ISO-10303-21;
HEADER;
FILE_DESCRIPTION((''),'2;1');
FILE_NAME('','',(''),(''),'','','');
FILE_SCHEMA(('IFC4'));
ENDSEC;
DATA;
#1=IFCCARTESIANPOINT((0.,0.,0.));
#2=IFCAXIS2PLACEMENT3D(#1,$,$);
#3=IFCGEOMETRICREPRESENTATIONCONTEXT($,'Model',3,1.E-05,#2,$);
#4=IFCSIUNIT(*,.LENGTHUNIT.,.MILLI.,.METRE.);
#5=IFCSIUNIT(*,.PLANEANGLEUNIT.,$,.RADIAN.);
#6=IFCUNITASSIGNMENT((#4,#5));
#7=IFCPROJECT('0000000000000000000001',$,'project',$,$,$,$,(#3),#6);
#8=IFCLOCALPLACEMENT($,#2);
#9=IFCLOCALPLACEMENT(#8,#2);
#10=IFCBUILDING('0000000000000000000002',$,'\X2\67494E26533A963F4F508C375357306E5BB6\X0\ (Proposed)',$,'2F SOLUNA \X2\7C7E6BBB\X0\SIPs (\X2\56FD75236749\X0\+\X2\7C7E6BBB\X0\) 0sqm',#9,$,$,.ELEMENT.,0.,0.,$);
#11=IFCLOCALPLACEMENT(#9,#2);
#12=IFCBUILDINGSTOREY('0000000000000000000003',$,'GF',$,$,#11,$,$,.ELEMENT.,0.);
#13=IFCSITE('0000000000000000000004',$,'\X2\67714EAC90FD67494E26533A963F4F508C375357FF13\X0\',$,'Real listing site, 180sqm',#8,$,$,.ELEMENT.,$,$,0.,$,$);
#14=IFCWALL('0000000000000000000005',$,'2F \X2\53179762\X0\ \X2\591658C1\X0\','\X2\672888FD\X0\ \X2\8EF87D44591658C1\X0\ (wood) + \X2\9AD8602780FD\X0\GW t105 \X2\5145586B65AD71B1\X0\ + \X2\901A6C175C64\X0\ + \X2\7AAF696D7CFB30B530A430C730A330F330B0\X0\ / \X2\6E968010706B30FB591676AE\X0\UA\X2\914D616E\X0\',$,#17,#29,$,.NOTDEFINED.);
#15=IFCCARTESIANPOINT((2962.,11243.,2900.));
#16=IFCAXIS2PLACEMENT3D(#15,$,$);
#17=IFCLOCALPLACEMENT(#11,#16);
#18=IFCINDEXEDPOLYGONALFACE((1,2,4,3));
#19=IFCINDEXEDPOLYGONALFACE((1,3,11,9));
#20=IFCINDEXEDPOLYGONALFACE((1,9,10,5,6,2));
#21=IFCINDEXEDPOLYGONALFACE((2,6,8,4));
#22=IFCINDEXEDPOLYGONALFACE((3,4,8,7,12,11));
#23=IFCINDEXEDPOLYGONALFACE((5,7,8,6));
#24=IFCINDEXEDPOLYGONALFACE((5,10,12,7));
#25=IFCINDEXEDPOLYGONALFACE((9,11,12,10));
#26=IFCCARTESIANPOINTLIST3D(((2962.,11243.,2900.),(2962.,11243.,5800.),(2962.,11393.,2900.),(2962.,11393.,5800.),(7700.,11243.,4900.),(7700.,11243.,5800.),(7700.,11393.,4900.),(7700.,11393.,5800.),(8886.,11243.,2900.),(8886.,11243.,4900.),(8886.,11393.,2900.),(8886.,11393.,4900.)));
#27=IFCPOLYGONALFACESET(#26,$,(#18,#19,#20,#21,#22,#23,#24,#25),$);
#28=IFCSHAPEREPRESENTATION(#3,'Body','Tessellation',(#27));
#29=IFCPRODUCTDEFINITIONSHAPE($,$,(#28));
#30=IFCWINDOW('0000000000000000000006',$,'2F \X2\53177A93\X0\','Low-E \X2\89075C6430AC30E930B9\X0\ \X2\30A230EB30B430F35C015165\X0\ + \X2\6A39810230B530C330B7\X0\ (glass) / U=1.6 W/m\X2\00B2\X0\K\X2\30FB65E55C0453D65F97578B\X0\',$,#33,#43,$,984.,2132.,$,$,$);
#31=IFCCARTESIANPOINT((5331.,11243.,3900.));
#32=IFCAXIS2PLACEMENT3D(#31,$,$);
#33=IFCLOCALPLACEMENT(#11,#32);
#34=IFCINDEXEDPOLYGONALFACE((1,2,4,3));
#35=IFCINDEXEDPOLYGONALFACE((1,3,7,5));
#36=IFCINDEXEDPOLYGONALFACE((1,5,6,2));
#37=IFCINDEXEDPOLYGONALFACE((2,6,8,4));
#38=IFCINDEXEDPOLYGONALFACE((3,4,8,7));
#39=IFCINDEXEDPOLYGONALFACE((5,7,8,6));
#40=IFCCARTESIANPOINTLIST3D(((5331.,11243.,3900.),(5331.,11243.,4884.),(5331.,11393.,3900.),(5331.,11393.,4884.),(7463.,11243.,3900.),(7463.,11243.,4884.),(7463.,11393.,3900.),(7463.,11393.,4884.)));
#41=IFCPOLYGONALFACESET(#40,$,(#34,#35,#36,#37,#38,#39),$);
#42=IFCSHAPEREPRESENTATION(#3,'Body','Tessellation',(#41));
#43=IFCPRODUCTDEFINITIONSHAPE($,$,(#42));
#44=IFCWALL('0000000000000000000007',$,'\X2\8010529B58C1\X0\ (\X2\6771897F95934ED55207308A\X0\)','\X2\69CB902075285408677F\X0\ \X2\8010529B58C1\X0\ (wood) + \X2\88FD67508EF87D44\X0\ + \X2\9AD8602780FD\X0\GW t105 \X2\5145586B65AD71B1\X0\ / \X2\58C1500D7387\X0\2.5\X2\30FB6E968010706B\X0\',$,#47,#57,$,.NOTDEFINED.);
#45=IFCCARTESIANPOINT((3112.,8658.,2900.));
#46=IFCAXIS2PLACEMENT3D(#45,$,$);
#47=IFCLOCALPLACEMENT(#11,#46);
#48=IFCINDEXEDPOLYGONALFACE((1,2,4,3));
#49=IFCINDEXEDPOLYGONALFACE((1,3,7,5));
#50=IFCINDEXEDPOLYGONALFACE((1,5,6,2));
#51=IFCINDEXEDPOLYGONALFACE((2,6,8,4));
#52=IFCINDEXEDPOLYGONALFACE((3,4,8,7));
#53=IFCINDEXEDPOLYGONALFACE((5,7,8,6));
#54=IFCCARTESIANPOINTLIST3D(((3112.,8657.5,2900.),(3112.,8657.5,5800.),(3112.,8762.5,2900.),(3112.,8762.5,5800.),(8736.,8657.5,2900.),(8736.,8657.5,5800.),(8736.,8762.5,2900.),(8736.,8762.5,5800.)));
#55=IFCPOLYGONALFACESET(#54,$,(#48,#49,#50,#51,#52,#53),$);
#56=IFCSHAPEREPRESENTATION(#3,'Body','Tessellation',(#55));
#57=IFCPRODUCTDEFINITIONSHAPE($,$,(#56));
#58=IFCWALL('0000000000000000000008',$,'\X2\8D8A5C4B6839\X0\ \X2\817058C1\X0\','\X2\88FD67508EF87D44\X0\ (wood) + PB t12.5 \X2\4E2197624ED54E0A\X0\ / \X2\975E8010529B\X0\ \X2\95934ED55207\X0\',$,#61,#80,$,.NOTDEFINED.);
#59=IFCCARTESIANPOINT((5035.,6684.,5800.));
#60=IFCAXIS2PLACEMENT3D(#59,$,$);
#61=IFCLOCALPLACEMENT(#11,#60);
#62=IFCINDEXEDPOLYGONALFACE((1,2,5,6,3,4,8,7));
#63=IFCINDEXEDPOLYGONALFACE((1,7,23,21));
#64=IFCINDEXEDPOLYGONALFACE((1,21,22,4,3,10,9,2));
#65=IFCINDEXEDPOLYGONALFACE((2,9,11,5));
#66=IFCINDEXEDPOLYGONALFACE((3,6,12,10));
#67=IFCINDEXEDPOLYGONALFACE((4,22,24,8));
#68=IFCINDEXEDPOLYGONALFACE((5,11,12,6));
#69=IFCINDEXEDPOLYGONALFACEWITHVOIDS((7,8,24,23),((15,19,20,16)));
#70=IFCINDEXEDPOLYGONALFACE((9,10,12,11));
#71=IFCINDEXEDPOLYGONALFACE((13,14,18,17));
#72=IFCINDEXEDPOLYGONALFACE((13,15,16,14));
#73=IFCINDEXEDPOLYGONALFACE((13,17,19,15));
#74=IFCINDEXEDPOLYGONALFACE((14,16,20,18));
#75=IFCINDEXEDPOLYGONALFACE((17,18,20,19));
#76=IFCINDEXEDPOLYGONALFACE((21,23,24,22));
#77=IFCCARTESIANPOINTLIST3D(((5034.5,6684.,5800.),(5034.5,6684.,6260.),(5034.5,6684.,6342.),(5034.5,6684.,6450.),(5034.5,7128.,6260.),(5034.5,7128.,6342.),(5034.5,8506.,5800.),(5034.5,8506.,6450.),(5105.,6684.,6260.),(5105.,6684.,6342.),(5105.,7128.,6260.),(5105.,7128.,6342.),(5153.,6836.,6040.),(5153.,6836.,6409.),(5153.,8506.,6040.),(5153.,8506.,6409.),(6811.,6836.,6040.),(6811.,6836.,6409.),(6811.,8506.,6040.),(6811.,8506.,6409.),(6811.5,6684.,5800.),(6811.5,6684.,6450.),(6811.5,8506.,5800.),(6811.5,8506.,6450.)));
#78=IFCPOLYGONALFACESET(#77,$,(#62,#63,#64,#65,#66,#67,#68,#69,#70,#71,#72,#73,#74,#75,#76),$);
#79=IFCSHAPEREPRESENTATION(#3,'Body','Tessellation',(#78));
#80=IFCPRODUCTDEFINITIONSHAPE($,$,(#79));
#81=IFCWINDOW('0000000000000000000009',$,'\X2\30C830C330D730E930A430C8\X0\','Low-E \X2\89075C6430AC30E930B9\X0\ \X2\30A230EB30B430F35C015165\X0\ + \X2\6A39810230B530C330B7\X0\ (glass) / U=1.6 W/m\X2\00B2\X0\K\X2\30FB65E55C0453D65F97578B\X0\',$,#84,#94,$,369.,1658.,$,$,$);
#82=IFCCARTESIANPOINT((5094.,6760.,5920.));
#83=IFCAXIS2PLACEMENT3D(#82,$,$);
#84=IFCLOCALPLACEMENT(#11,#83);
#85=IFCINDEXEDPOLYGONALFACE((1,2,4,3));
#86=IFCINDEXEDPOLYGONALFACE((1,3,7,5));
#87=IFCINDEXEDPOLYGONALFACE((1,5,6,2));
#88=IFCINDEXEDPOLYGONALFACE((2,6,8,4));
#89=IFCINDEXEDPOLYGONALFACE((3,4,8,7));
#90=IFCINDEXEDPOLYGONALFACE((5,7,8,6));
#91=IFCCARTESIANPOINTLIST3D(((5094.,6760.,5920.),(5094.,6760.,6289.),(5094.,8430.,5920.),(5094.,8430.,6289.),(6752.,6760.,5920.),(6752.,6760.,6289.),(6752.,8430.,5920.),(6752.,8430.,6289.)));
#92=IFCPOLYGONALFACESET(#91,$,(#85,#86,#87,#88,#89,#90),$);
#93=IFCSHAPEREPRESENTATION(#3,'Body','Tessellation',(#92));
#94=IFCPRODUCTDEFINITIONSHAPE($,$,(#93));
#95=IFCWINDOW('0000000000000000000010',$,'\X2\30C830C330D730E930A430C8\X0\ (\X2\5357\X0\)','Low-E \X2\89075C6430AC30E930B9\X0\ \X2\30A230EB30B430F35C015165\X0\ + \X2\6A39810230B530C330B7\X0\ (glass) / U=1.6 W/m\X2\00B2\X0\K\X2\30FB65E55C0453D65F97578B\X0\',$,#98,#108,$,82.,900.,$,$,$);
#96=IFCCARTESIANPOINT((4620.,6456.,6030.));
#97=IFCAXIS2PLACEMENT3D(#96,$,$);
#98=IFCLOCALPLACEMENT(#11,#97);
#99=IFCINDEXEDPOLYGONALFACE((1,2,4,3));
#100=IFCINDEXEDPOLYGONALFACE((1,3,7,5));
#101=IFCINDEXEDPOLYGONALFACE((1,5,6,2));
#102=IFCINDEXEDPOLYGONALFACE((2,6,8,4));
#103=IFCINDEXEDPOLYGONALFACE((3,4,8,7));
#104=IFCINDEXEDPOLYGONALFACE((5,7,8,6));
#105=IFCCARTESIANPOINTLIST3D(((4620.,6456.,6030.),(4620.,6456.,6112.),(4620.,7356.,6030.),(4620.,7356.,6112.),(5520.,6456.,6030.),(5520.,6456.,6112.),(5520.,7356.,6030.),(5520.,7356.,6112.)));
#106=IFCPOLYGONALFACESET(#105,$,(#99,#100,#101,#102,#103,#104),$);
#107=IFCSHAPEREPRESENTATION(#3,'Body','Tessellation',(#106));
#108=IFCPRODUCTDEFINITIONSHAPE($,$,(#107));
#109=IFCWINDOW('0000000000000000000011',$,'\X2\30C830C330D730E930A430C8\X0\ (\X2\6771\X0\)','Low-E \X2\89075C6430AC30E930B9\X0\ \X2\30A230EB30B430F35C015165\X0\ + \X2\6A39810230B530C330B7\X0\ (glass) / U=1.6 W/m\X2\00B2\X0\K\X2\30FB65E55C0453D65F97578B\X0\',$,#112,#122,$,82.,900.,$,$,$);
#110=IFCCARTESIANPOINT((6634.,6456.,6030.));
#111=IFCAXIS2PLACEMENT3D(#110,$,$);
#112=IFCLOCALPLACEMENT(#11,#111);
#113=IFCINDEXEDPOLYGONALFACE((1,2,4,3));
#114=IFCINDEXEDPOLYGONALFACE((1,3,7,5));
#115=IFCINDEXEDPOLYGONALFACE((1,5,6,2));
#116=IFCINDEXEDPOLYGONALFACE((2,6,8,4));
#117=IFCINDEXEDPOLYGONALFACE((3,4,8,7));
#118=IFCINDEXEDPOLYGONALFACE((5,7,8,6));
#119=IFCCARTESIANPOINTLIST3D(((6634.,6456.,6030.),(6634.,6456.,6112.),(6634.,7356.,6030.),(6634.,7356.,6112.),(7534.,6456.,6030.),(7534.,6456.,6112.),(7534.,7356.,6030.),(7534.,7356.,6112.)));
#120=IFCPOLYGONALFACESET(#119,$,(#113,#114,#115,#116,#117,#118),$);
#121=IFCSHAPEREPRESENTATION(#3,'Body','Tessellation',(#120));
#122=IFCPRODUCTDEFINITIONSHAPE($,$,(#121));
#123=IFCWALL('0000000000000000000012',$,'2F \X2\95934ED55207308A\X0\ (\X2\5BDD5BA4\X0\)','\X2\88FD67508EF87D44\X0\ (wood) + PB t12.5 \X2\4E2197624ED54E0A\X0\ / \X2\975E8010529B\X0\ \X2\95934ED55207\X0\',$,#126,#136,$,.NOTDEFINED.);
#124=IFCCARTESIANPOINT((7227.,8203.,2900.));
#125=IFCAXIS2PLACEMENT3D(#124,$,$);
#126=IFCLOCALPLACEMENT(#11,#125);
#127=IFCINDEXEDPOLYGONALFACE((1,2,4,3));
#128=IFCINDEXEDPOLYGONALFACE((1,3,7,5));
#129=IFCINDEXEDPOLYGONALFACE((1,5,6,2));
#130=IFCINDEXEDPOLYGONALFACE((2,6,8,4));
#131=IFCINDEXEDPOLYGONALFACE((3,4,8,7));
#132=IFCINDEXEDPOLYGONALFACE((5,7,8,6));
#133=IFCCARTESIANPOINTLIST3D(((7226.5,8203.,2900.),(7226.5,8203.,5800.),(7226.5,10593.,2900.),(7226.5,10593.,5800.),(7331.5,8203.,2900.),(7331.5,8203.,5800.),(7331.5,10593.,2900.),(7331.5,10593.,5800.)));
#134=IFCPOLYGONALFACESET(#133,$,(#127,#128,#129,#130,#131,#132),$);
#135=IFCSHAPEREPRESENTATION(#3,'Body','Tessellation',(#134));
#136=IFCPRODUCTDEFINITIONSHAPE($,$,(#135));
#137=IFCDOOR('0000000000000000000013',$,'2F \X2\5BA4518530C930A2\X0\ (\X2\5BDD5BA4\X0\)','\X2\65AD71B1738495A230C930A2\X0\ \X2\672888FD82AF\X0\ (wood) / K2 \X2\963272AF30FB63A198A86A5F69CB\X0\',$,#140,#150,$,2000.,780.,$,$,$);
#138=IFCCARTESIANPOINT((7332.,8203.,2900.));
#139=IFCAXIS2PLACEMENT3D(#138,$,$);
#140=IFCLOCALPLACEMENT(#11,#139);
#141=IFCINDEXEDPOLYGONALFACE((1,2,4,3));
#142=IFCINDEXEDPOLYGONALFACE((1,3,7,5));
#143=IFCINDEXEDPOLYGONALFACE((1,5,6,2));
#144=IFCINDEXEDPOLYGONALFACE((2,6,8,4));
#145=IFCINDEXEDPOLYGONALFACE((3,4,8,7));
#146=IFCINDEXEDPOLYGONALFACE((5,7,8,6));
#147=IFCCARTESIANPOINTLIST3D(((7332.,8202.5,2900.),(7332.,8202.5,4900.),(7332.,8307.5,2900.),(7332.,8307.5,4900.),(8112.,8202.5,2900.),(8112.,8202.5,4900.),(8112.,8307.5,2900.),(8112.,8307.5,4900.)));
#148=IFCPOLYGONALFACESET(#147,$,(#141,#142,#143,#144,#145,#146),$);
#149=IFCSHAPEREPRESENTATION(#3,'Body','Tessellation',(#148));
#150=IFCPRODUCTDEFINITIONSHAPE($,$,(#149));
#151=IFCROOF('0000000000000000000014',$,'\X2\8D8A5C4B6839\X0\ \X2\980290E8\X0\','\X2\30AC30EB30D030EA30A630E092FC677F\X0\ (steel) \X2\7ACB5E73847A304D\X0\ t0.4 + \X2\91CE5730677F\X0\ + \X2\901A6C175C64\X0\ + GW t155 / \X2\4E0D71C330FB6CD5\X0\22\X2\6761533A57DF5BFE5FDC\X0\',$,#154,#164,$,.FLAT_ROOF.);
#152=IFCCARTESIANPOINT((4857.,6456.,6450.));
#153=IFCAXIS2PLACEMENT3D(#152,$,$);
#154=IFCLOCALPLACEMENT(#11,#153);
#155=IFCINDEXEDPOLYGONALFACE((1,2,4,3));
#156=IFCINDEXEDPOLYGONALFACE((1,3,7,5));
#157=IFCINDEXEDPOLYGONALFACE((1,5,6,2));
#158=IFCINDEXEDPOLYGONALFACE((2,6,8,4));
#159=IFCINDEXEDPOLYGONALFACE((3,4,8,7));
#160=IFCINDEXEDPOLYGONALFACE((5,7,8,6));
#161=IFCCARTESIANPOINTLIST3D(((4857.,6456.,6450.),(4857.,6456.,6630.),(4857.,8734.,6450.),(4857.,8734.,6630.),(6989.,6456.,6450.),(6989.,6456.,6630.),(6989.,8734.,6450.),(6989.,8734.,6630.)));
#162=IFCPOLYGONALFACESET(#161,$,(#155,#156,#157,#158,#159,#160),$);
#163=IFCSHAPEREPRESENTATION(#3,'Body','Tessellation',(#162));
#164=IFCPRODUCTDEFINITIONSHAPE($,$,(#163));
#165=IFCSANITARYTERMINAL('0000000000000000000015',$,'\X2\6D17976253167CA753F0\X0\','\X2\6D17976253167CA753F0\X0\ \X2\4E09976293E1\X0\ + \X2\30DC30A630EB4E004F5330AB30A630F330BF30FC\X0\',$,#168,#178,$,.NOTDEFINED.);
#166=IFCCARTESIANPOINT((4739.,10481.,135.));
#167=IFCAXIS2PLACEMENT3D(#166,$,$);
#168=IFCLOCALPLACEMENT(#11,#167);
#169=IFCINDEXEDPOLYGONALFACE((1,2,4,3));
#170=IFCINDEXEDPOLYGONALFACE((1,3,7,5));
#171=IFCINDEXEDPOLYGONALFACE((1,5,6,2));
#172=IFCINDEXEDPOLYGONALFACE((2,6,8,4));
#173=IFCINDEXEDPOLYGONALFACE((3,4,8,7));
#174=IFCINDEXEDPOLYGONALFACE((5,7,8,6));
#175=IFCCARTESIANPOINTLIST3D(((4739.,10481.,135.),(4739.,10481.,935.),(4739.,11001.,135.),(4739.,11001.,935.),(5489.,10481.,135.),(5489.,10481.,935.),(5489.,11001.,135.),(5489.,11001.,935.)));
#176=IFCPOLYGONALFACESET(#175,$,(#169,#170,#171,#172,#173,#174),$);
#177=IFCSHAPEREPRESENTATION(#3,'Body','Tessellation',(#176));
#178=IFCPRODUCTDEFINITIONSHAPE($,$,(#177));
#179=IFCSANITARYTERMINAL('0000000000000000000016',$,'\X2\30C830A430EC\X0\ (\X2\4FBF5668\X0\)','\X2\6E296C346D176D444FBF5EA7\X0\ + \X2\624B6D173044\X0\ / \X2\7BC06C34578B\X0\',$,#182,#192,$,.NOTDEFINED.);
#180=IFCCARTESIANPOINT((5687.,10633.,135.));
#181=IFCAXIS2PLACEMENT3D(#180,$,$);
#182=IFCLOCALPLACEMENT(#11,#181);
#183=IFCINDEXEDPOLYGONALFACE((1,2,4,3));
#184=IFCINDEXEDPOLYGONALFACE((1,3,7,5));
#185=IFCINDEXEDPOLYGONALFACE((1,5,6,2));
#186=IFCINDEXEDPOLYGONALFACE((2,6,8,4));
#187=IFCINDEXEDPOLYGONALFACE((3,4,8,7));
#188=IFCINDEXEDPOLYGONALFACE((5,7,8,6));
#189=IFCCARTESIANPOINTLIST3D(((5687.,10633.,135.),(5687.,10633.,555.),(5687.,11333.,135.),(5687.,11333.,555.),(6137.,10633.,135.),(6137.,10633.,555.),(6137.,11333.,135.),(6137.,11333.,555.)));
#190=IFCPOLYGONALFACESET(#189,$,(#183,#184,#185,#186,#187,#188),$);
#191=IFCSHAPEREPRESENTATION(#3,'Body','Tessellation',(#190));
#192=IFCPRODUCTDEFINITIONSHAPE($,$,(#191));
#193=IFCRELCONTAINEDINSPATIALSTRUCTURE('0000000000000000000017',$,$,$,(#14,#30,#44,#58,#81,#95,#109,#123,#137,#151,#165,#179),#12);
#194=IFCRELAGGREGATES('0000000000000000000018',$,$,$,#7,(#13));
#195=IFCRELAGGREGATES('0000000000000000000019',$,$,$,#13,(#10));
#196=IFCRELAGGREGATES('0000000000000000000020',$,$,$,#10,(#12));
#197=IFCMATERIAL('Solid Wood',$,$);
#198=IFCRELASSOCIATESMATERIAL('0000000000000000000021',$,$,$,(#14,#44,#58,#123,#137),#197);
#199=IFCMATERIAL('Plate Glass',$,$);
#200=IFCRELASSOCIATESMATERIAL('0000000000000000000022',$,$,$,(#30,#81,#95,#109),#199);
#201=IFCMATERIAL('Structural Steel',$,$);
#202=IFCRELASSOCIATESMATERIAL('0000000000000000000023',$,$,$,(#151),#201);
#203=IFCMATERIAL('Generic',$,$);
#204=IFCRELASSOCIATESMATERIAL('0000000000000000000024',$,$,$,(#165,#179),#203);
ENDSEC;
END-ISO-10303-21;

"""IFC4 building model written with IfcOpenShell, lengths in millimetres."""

from ifc_helpers import new_model, si_unit, frame, frame_2d, origin, place, context, project, spatial, rectangle, extrude, material, element, fill, save


model = new_model("IFC4")

# Units and contexts
model_context = context("Model", 3, precision=1e-05, world=origin())
ifc_project = project(units=[si_unit("LENGTHUNIT", "METRE", prefix="MILLI"), si_unit("PLANEANGLEUNIT", "RADIAN")], contexts=[model_context])

# Site, building, storey
site_placement = place(None, origin())
site = spatial("IfcSite", under=ifc_project, at=site_placement, Name="東京都杉並区阿佐谷南３", ObjectType="Real listing site, 180sqm", CompositionType="ELEMENT", RefElevation=0.0)
building_placement = place(site_placement, origin())
building = spatial("IfcBuilding", under=site, at=building_placement, Name="杉並区阿佐谷南の家 (Proposed)", ObjectType="2F SOLUNA 籾殻SIPs (国産杉+籾殻) 0sqm", CompositionType="ELEMENT", ElevationOfRefHeight=0.0, ElevationOfTerrain=0.0)
storey_placement = place(building_placement, origin())
storey = spatial("IfcBuildingStorey", under=building, at=storey_placement, Name="GF", CompositionType="ELEMENT", Elevation=0.0)

# Wall, opening, window
ifc_material_1 = material(Name="Solid Wood")
wall_1_placement = place(storey_placement, frame((2962.0, 11243.0, 2900.0)))
wall_1 = element("IfcWall", 1, at=wall_1_placement, inside=storey, material=ifc_material_1, Name="2F 北面 外壁", Description="木製 軸組外壁 (wood) + 高性能GW t105 充填断熱 + 通気層 + 窯業系サイディング / 準耐火・外皮UA配慮", PredefinedType="NOTDEFINED", context=model_context, shape_type="SweptSolid", body=[
    extrude(rectangle(XDim=5924.0, YDim=150.0, at=frame_2d((2962.0, 75.0))), frame((2962.0, 11243.0, 2900.0)), (0.0, 0.0, 1.0), 2900.0),
])
opening_1_placement = place(storey_placement, frame((5331.0, 11243.0, 3900.0)))
opening_1 = element("IfcOpeningElement", 2, at=opening_1_placement, cuts=wall_1, PredefinedType="NOTDEFINED", context=model_context, shape_type="SweptSolid", body=[
    extrude(rectangle(XDim=2132.0, YDim=150.0, at=frame_2d((1066.0, 75.0))), frame((5331.0, 11243.0, 3900.0)), (0.0, 0.0, 1.0), 984.0),
])
ifc_material_2 = material(Name="Plate Glass")
window_1_placement = place(storey_placement, frame((5331.0, 11243.0, 3900.0)))
window_1 = element("IfcWindow", 3, at=window_1_placement, inside=storey, material=ifc_material_2, Name="2F 北窓", Description="Low-E 複層ガラス アルゴン封入 + 樹脂サッシ (glass) / U=1.6 W/m²K・日射取得型", OverallHeight=984.0, OverallWidth=2132.0, context=model_context, shape_type="SweptSolid", body=[
    extrude(rectangle(XDim=2132.0, YDim=150.0, at=frame_2d((1066.0, 75.0))), frame((5331.0, 11243.0, 3900.0)), (0.0, 0.0, 1.0), 984.0),
])
fill(opening_1, window_1)

# Wall
wall_2_placement = place(storey_placement, frame((3112.0, 8658.0, 2900.0)))
element("IfcWall", 4, at=wall_2_placement, inside=storey, material=ifc_material_1, Name="耐力壁 (東西間仕切り)", Description="構造用合板 耐力壁 (wood) + 製材軸組 + 高性能GW t105 充填断熱 / 壁倍率2.5・準耐火", PredefinedType="NOTDEFINED", context=model_context, shape_type="SweptSolid", body=[
    extrude(rectangle(XDim=5624.0, YDim=105.0, at=frame_2d((2812.0, 52.0))), frame((3112.0, 8658.0, 2900.0)), (0.0, 0.0, 1.0), 2900.0),
])

# Wall, openings, windows
wall_3_placement = place(storey_placement, frame((5035.0, 6684.0, 5800.0)))
wall_3 = element("IfcWall", 5, at=wall_3_placement, inside=storey, material=ifc_material_1, Name="越屋根 腰壁", Description="製材軸組 (wood) + PB t12.5 両面仕上 / 非耐力 間仕切", PredefinedType="NOTDEFINED", context=model_context, shape_type="SweptSolid", body=[
    extrude(rectangle(XDim=1777.0, YDim=1822.0, at=frame_2d((888.0, 911.0))), frame((5035.0, 6684.0, 5800.0)), (0.0, 0.0, 1.0), 650.0),
])
opening_2_placement = place(storey_placement, frame((5094.0, 6760.0, 5920.0)))
opening_2 = element("IfcOpeningElement", 6, at=opening_2_placement, cuts=wall_3, PredefinedType="NOTDEFINED", context=model_context, shape_type="SweptSolid", body=[
    extrude(rectangle(XDim=1658.0, YDim=1670.0, at=frame_2d((829.0, 835.0))), frame((5094.0, 6760.0, 5920.0)), (0.0, 0.0, 1.0), 369.0),
])
opening_3_placement = place(storey_placement, frame((4620.0, 6456.0, 6030.0)))
opening_3 = element("IfcOpeningElement", 7, at=opening_3_placement, cuts=wall_3, PredefinedType="NOTDEFINED", context=model_context, shape_type="SweptSolid", body=[
    extrude(rectangle(XDim=900.0, YDim=900.0, at=frame_2d((450.0, 450.0))), frame((4620.0, 6456.0, 6030.0)), (0.0, 0.0, 1.0), 82.0),
])
opening_4_placement = place(storey_placement, frame((6634.0, 6456.0, 6030.0)))
opening_4 = element("IfcOpeningElement", 8, at=opening_4_placement, cuts=wall_3, PredefinedType="NOTDEFINED", context=model_context, shape_type="SweptSolid", body=[
    extrude(rectangle(XDim=900.0, YDim=900.0, at=frame_2d((450.0, 450.0))), frame((6634.0, 6456.0, 6030.0)), (0.0, 0.0, 1.0), 82.0),
])
window_2_placement = place(storey_placement, frame((5094.0, 6760.0, 5920.0)))
window_2 = element("IfcWindow", 9, at=window_2_placement, inside=storey, material=ifc_material_2, Name="トップライト", Description="Low-E 複層ガラス アルゴン封入 + 樹脂サッシ (glass) / U=1.6 W/m²K・日射取得型", OverallHeight=369.0, OverallWidth=1658.0, context=model_context, shape_type="SweptSolid", body=[
    extrude(rectangle(XDim=1658.0, YDim=1670.0, at=frame_2d((829.0, 835.0))), frame((5094.0, 6760.0, 5920.0)), (0.0, 0.0, 1.0), 369.0),
])
fill(opening_2, window_2)
window_3_placement = place(storey_placement, frame((4620.0, 6456.0, 6030.0)))
window_3 = element("IfcWindow", 10, at=window_3_placement, inside=storey, material=ifc_material_2, Name="トップライト (南)", Description="Low-E 複層ガラス アルゴン封入 + 樹脂サッシ (glass) / U=1.6 W/m²K・日射取得型", OverallHeight=82.0, OverallWidth=900.0, context=model_context, shape_type="SweptSolid", body=[
    extrude(rectangle(XDim=900.0, YDim=900.0, at=frame_2d((450.0, 450.0))), frame((4620.0, 6456.0, 6030.0)), (0.0, 0.0, 1.0), 82.0),
])
fill(opening_3, window_3)
window_4_placement = place(storey_placement, frame((6634.0, 6456.0, 6030.0)))
window_4 = element("IfcWindow", 11, at=window_4_placement, inside=storey, material=ifc_material_2, Name="トップライト (東)", Description="Low-E 複層ガラス アルゴン封入 + 樹脂サッシ (glass) / U=1.6 W/m²K・日射取得型", OverallHeight=82.0, OverallWidth=900.0, context=model_context, shape_type="SweptSolid", body=[
    extrude(rectangle(XDim=900.0, YDim=900.0, at=frame_2d((450.0, 450.0))), frame((6634.0, 6456.0, 6030.0)), (0.0, 0.0, 1.0), 82.0),
])
fill(opening_4, window_4)

# Wall
wall_4_placement = place(storey_placement, frame((7227.0, 8203.0, 2900.0)))
element("IfcWall", 12, at=wall_4_placement, inside=storey, material=ifc_material_1, Name="2F 間仕切り (寝室)", Description="製材軸組 (wood) + PB t12.5 両面仕上 / 非耐力 間仕切", PredefinedType="NOTDEFINED", context=model_context, shape_type="SweptSolid", body=[
    extrude(rectangle(XDim=105.0, YDim=2390.0, at=frame_2d((52.0, 1195.0))), frame((7227.0, 8203.0, 2900.0)), (0.0, 0.0, 1.0), 2900.0),
])

# Door
door_placement = place(storey_placement, frame((7332.0, 8203.0, 2900.0)))
element("IfcDoor", 13, at=door_placement, inside=storey, material=ifc_material_1, Name="2F 室内ドア (寝室)", Description="断熱玄関ドア 木製芯 (wood) / K2 防犯・採風機構", OverallHeight=2000.0, OverallWidth=780.0, context=model_context, shape_type="SweptSolid", body=[
    extrude(rectangle(XDim=780.0, YDim=105.0, at=frame_2d((390.0, 52.0))), frame((7332.0, 8203.0, 2900.0)), (0.0, 0.0, 1.0), 2000.0),
])

# Roof
ifc_material_3 = material(Name="Structural Steel")
roof_placement = place(storey_placement, frame((4857.0, 6456.0, 6450.0)))
element("IfcRoof", 14, at=roof_placement, inside=storey, material=ifc_material_3, Name="越屋根 頂部", Description="ガルバリウム鋼板 (steel) 立平葺き t0.4 + 野地板 + 通気層 + GW t155 / 不燃・法22条区域対応", PredefinedType="FLAT_ROOF", context=model_context, shape_type="SweptSolid", body=[
    extrude(rectangle(XDim=2132.0, YDim=2278.0, at=frame_2d((1066.0, 1139.0))), frame((4857.0, 6456.0, 6450.0)), (0.0, 0.0, 1.0), 180.0),
])

# Sanitary terminals
ifc_material_4 = material(Name="Generic")
sanitary_terminal_1_placement = place(storey_placement, frame((4739.0, 10481.0, 135.0)))
element("IfcSanitaryTerminal", 15, at=sanitary_terminal_1_placement, inside=storey, material=ifc_material_4, Name="洗面化粧台", Description="洗面化粧台 三面鏡 + ボウル一体カウンター", PredefinedType="NOTDEFINED", context=model_context, shape_type="SweptSolid", body=[
    extrude(rectangle(XDim=750.0, YDim=520.0, at=frame_2d((375.0, 260.0))), frame((4739.0, 10481.0, 135.0)), (0.0, 0.0, 1.0), 800.0),
])
sanitary_terminal_2_placement = place(storey_placement, frame((5687.0, 10633.0, 135.0)))
element("IfcSanitaryTerminal", 16, at=sanitary_terminal_2_placement, inside=storey, material=ifc_material_4, Name="トイレ (便器)", Description="温水洗浄便座 + 手洗い / 節水型", PredefinedType="NOTDEFINED", context=model_context, shape_type="SweptSolid", body=[
    extrude(rectangle(XDim=450.0, YDim=700.0, at=frame_2d((225.0, 350.0))), frame((5687.0, 10633.0, 135.0)), (0.0, 0.0, 1.0), 420.0),
])

save(model, "model.ifc")
